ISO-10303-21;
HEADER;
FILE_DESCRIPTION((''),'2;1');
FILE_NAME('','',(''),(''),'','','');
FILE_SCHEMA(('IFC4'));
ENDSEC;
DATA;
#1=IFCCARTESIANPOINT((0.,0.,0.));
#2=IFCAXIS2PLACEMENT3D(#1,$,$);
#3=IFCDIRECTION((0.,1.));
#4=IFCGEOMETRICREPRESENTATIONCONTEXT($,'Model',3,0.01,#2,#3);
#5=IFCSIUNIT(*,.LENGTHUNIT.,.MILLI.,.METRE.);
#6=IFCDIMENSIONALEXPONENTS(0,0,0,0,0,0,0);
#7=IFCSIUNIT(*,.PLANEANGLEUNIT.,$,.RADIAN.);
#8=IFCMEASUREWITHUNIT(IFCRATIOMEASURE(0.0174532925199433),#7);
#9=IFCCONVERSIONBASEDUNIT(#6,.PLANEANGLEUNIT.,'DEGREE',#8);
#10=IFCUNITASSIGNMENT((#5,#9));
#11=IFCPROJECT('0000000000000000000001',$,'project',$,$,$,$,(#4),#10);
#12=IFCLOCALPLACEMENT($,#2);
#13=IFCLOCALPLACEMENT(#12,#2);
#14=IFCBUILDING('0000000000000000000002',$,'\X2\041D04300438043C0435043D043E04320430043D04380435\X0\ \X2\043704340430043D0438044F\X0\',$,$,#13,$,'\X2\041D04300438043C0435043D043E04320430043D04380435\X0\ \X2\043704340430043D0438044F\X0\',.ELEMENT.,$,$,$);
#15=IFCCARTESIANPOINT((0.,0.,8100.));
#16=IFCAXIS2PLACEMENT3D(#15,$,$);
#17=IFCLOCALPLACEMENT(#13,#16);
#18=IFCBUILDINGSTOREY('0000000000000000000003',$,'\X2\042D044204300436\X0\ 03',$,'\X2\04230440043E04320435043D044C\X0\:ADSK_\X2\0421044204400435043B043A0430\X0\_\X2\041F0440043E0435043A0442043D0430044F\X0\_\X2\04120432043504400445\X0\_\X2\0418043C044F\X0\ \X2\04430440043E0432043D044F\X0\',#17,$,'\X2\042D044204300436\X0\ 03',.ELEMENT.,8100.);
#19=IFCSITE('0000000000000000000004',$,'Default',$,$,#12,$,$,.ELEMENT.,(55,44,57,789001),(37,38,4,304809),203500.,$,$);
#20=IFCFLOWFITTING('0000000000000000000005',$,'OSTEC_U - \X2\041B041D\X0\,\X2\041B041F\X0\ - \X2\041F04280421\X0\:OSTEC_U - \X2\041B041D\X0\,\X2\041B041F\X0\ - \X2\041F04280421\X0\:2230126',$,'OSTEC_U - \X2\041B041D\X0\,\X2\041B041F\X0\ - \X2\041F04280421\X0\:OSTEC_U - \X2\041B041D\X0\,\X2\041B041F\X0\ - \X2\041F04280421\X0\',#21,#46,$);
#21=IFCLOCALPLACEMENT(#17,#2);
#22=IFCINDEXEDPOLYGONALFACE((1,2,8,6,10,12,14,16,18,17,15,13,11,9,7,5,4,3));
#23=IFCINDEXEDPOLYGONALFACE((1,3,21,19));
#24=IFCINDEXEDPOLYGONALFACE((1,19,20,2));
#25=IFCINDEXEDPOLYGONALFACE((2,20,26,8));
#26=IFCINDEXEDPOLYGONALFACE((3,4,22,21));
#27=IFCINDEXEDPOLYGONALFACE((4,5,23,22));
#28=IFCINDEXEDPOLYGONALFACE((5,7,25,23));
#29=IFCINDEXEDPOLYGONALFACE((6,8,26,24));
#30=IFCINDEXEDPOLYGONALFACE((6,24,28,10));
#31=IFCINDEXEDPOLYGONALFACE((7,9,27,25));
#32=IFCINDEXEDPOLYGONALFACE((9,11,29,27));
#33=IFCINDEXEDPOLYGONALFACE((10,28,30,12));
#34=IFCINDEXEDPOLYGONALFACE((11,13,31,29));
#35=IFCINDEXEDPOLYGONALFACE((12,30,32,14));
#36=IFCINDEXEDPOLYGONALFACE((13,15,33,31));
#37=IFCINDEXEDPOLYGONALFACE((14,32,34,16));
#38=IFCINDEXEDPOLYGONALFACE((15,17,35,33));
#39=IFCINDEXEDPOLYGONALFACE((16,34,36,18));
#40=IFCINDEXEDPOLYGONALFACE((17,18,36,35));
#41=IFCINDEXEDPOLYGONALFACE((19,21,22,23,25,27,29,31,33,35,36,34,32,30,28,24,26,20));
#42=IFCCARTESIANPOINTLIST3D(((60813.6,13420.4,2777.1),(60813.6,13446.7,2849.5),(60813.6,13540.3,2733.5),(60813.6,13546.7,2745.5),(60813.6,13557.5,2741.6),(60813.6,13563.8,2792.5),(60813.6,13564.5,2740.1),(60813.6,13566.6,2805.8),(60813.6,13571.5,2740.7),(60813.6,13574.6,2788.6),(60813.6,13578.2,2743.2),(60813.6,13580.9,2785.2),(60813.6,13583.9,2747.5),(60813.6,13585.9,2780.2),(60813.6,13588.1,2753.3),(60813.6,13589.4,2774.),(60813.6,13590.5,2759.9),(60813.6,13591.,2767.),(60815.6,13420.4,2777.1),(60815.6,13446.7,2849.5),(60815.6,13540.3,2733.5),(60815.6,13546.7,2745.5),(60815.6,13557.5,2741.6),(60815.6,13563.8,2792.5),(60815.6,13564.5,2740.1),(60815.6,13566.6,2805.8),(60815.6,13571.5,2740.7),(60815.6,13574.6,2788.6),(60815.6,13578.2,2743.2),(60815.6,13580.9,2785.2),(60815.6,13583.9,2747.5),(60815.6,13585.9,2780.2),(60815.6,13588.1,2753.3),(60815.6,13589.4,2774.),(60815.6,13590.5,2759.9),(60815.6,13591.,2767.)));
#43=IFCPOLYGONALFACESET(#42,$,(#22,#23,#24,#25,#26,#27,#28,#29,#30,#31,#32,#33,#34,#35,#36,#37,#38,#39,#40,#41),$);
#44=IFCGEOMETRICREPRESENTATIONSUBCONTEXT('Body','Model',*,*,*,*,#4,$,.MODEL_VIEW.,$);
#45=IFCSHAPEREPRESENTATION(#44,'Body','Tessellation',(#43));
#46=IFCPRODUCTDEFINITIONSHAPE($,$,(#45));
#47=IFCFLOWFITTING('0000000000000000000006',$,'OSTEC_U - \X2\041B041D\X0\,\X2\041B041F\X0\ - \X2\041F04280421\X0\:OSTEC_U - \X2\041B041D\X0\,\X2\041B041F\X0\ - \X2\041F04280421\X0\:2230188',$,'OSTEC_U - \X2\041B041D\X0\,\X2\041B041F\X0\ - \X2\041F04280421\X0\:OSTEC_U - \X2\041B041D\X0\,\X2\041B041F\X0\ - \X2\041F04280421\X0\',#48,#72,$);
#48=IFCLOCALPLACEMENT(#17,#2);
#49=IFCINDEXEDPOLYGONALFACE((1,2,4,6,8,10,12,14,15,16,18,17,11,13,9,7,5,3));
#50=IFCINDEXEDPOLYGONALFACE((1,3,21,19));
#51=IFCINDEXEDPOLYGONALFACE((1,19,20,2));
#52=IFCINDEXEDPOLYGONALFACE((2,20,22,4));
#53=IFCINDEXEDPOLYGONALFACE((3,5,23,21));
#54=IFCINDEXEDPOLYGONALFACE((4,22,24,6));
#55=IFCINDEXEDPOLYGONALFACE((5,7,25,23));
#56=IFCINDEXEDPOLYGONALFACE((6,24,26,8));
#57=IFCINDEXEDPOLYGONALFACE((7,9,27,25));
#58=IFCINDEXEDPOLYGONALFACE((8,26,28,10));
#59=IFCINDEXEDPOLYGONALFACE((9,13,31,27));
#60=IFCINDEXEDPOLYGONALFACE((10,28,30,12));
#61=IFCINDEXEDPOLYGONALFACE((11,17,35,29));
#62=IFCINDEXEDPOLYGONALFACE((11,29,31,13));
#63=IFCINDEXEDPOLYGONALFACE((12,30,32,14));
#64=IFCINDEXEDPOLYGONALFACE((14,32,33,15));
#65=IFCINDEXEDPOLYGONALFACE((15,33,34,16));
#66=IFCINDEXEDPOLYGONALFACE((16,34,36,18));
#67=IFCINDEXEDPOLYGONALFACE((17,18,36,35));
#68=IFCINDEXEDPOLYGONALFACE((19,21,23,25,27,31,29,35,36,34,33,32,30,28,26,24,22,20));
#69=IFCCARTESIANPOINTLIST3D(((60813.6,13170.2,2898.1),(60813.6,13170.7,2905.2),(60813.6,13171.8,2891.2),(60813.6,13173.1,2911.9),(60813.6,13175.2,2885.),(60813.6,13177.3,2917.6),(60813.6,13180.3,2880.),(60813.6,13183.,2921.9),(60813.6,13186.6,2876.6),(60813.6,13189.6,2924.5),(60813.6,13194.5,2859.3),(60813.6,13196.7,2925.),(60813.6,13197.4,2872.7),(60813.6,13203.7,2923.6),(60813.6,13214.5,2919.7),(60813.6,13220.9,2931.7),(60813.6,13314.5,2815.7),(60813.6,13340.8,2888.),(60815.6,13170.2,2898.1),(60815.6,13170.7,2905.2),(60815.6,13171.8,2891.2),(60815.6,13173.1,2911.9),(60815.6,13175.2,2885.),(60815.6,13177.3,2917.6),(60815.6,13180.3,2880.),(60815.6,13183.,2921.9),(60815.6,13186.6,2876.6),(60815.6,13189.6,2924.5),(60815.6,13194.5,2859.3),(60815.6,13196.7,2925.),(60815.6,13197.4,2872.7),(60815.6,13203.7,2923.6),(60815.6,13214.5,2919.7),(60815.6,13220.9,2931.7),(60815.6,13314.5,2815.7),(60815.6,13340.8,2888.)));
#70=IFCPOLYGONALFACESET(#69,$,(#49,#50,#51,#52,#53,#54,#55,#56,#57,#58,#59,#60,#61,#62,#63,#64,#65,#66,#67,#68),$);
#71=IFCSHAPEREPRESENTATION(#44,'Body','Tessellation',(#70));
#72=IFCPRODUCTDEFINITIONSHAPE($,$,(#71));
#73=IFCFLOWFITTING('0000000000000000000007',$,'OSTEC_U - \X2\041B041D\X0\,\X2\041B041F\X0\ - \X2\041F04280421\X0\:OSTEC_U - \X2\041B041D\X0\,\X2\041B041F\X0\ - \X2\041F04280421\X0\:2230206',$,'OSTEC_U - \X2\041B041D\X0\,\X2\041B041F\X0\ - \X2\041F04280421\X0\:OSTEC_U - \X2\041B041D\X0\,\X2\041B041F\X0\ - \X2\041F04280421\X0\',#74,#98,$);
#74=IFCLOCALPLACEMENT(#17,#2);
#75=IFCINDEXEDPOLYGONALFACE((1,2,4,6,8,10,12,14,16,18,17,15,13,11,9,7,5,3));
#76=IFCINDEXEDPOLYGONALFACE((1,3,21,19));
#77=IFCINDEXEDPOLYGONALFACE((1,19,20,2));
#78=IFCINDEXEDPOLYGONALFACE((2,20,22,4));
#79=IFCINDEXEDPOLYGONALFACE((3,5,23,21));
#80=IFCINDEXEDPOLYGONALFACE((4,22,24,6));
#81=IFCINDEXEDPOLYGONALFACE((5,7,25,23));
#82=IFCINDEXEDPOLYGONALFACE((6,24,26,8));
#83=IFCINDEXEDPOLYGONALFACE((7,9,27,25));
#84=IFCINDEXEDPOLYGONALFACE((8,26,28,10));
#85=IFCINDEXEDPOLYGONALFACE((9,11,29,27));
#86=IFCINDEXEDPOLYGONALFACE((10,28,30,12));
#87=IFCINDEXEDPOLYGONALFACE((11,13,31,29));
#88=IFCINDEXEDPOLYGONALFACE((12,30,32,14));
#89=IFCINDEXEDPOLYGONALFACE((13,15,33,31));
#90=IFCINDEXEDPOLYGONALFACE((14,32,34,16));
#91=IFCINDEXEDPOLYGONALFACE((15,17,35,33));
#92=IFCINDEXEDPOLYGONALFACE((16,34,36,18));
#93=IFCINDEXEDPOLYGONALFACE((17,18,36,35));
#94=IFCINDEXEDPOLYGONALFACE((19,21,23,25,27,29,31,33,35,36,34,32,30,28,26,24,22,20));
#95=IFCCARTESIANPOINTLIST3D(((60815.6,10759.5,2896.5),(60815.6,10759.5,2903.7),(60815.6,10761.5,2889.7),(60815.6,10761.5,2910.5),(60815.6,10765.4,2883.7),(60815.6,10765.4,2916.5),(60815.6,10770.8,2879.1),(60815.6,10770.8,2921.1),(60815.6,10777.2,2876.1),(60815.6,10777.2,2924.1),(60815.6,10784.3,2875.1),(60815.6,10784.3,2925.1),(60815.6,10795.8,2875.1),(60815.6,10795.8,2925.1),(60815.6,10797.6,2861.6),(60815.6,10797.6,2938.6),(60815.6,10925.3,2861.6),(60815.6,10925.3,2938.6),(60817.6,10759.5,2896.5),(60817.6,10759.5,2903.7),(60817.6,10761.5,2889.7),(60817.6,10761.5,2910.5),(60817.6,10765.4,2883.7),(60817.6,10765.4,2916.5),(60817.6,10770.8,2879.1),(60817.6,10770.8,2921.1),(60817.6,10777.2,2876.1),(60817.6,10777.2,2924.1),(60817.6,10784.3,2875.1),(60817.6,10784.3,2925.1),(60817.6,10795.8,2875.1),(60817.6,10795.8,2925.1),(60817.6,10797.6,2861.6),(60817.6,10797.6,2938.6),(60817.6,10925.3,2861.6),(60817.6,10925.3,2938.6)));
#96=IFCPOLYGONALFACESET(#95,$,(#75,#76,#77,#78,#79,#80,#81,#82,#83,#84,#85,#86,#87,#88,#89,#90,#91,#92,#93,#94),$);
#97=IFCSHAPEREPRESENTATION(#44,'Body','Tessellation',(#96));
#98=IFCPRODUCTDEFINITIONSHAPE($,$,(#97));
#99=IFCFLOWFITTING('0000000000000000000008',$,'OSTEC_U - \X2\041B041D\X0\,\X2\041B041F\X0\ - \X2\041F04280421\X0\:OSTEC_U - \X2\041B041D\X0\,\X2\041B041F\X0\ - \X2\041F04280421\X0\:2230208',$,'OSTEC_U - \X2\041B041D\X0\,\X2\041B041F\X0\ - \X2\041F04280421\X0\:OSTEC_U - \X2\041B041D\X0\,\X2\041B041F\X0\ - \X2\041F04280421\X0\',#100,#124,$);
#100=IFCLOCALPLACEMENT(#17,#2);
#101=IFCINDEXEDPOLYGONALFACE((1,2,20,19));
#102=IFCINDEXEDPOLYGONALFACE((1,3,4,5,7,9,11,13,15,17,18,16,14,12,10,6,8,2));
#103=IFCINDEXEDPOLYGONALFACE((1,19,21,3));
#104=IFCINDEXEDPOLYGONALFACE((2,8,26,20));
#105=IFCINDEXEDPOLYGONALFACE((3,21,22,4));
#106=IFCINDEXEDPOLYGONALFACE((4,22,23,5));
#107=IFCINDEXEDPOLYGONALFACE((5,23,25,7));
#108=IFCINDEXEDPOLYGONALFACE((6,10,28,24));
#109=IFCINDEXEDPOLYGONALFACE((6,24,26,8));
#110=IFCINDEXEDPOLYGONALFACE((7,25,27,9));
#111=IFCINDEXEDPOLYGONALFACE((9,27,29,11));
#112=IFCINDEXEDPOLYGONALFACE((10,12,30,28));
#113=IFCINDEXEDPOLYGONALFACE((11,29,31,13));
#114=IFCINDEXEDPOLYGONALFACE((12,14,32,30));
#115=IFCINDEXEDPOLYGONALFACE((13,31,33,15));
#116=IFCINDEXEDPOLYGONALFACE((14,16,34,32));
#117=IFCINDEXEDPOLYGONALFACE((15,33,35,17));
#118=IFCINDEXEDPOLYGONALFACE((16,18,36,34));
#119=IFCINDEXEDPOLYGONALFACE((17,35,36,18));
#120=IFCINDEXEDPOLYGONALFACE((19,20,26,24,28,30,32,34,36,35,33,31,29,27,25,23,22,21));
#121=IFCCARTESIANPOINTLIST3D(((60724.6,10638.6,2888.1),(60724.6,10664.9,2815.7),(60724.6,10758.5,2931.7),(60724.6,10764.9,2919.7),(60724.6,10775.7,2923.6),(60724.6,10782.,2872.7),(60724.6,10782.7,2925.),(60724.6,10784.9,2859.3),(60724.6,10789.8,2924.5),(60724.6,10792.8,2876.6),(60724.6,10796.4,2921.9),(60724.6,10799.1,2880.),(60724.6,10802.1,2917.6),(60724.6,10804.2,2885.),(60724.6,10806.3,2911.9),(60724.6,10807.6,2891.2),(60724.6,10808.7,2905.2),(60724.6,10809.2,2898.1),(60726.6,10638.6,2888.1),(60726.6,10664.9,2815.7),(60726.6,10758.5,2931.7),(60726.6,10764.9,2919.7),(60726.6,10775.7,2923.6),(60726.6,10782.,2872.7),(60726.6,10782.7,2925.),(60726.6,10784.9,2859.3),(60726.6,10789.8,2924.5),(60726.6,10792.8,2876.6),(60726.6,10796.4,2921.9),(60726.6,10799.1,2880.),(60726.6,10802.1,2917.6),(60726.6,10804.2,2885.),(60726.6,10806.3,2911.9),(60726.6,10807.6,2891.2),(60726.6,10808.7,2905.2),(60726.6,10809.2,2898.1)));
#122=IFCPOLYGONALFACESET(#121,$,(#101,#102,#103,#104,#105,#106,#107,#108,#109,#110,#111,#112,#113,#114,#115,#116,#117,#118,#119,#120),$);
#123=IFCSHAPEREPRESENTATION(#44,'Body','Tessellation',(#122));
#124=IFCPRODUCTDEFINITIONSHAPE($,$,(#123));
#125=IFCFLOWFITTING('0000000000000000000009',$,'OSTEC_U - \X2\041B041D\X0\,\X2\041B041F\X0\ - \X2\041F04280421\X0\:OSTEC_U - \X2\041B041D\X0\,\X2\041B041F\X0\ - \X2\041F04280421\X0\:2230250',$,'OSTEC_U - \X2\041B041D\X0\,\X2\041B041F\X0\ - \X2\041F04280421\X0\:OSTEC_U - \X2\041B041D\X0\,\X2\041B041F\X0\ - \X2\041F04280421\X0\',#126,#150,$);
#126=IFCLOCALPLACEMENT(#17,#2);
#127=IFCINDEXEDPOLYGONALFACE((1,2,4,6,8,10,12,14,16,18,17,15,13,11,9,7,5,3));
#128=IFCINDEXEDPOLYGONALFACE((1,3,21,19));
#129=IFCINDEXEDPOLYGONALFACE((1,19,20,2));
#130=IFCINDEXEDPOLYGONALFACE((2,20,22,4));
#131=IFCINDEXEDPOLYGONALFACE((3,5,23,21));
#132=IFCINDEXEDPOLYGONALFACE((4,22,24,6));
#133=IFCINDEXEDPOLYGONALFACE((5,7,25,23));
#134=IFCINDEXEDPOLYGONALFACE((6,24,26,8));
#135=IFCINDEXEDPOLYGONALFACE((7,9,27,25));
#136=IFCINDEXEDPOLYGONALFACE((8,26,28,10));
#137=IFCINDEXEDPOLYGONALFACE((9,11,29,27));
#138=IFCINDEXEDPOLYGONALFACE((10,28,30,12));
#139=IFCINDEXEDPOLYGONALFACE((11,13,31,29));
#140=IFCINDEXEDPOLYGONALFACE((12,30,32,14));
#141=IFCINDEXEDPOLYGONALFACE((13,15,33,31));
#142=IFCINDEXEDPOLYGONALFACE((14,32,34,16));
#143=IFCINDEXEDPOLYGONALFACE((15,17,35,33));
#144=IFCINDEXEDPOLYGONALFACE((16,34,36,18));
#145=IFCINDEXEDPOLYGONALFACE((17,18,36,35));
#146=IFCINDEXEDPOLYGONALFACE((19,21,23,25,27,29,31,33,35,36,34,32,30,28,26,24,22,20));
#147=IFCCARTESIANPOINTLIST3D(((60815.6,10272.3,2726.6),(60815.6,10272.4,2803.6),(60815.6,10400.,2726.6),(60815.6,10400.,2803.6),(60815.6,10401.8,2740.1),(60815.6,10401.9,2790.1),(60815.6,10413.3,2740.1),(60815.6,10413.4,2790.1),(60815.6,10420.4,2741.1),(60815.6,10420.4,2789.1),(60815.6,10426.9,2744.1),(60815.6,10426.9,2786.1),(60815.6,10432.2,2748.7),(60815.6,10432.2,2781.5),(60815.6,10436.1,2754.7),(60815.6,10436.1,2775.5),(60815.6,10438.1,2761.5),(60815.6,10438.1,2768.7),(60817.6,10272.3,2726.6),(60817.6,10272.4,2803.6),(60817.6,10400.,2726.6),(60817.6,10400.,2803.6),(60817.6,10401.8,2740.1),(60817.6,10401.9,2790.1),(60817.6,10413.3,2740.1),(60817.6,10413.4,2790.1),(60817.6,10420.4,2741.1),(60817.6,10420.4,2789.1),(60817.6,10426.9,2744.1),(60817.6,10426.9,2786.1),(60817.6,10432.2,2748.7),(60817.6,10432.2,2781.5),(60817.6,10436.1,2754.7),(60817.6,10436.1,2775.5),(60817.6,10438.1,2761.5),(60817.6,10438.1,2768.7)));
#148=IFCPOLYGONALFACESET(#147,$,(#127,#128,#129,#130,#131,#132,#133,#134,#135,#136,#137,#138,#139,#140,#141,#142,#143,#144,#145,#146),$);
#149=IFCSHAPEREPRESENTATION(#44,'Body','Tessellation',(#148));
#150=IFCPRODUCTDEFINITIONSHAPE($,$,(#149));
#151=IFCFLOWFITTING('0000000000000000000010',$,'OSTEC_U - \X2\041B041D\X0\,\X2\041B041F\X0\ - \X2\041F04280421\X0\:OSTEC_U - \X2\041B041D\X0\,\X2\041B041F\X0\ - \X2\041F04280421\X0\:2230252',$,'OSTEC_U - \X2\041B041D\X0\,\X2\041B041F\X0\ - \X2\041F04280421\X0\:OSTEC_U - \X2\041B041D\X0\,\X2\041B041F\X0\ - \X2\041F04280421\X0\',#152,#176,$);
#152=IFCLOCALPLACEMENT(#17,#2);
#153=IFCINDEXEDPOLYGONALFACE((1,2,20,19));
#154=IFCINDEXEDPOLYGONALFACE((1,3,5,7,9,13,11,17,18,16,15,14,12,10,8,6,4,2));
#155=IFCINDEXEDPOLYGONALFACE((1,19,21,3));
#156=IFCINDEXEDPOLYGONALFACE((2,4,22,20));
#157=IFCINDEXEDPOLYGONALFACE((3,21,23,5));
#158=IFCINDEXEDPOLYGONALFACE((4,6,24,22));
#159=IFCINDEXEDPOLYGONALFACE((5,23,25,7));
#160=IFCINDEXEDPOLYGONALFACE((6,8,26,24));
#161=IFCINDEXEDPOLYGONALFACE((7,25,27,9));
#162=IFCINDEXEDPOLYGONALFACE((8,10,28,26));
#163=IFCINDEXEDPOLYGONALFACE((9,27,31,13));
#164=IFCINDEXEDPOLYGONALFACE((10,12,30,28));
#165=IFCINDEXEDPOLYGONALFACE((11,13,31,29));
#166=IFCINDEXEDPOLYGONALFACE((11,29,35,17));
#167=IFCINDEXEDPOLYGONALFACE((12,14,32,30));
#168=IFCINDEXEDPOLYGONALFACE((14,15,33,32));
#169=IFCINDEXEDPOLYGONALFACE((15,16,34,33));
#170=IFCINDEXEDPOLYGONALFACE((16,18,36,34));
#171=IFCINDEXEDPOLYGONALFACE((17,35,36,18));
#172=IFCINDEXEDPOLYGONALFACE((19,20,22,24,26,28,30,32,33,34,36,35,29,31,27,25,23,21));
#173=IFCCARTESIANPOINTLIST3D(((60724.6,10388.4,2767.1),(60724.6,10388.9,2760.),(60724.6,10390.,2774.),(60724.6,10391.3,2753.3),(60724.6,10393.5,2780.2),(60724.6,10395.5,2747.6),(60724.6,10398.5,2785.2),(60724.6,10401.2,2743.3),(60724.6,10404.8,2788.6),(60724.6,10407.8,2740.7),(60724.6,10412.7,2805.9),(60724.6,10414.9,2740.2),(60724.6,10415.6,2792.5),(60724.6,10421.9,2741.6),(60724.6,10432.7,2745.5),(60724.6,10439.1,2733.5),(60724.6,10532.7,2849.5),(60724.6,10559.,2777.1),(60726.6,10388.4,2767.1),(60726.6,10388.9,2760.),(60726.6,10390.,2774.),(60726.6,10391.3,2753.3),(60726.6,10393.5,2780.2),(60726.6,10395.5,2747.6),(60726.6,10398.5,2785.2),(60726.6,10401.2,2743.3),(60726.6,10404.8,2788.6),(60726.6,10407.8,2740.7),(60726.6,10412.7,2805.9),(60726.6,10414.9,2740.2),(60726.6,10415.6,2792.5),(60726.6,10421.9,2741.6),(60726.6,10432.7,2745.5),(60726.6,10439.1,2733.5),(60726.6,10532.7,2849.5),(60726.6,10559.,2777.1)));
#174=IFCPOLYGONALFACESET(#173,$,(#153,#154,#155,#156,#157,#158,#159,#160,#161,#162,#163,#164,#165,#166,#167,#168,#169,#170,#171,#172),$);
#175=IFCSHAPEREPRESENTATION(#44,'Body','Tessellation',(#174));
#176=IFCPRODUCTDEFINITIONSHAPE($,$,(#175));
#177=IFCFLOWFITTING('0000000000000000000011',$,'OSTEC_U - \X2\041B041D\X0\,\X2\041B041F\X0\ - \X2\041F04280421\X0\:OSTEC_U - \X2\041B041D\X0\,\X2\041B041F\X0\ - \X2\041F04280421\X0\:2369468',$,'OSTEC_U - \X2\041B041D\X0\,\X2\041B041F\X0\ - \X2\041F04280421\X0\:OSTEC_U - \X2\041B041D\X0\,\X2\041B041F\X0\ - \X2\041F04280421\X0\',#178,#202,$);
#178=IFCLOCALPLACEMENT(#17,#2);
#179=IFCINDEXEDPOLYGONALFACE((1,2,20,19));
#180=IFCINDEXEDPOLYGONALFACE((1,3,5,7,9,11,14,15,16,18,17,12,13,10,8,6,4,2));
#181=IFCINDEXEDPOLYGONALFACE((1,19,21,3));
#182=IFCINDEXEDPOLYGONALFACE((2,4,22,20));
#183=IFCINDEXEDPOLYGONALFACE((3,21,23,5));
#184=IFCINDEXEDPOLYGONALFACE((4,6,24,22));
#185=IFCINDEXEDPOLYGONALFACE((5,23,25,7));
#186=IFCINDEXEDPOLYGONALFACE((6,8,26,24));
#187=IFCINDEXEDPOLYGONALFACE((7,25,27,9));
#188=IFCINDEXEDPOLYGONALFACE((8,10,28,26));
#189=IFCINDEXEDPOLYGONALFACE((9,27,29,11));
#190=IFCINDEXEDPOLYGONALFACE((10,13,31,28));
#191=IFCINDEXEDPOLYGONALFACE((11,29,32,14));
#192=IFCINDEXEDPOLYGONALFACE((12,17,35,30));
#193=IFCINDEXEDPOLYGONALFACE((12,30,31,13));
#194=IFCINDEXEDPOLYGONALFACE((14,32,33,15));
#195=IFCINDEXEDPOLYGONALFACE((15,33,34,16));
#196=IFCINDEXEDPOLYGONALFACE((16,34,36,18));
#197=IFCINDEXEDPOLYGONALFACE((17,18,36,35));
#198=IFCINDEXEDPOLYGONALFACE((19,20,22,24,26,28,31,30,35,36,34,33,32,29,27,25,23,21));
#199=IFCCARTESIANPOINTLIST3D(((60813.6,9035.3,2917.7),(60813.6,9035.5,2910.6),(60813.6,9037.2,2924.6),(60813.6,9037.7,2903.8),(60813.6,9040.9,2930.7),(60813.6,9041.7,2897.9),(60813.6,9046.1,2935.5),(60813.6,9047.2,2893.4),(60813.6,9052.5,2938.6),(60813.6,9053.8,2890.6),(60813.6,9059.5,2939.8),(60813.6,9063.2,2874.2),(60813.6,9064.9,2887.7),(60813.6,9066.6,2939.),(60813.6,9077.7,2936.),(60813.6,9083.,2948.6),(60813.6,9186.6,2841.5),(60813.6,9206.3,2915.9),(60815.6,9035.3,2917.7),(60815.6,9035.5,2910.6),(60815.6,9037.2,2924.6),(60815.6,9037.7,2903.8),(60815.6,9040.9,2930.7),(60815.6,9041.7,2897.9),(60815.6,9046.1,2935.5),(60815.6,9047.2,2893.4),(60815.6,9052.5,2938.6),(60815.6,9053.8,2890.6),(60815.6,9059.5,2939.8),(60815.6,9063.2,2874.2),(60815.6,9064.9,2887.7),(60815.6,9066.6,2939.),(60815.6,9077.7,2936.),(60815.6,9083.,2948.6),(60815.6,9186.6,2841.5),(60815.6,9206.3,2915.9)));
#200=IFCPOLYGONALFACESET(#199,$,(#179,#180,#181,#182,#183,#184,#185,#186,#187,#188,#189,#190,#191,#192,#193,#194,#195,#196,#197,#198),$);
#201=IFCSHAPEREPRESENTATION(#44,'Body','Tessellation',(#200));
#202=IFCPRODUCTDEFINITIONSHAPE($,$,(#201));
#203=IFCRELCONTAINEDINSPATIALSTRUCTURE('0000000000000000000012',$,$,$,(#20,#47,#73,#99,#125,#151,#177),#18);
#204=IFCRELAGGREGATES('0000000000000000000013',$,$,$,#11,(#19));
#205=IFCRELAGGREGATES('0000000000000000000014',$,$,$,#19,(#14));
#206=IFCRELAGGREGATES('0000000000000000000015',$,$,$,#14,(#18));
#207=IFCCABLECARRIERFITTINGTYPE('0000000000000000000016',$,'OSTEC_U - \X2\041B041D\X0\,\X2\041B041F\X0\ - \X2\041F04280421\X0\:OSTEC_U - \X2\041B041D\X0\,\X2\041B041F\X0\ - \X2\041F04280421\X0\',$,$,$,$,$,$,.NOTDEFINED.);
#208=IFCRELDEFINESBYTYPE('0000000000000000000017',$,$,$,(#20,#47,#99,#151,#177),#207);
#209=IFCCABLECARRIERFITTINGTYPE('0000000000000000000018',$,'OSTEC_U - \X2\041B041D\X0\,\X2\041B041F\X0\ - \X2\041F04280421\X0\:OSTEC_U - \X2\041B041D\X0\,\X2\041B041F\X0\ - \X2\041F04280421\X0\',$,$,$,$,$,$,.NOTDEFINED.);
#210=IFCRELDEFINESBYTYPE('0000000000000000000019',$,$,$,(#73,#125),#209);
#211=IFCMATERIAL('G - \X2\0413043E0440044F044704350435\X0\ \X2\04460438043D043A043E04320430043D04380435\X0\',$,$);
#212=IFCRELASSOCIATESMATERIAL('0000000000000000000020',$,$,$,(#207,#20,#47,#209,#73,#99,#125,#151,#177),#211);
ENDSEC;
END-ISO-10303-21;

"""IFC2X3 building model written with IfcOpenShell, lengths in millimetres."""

from ifc_helpers import new_model, entity, si_unit, converted_unit, direction, frame, frame_2d, origin, place, context, subcontext, project, spatial, polyline, circle_curve, parameter, trimmed, segment, composite_curve, outline, extrude, source, transform, mapped, material, type_object, type_shapes, element, save


model = new_model("IFC2X3")

# Units and contexts
model_context = context("Model", 3, precision=0.01, world=origin(), true_north=direction((0.0, 1.0)))
body_context = subcontext(model_context, "Body", "Model", "MODEL_VIEW")
ifc_project = project(units=[si_unit("LENGTHUNIT", "METRE", prefix="MILLI"), converted_unit("PLANEANGLEUNIT", "DEGREE", entity("IfcRatioMeasure", 0.0174532925199433), si_unit("PLANEANGLEUNIT", "RADIAN"), dimensions=[0, 0, 0, 0, 0, 0, 0])], contexts=[model_context])

# Site, building, storey
site_placement = place(None, origin())
site = spatial("IfcSite", under=ifc_project, at=site_placement, Name="Default", CompositionType="ELEMENT", RefLatitude=(55, 44, 57, 789001), RefLongitude=(37, 38, 4, 304809), RefElevation=203500.0)
building_placement = place(site_placement, origin())
building = spatial("IfcBuilding", under=site, at=building_placement, Name="Наименование здания", LongName="Наименование здания", CompositionType="ELEMENT")
storey_placement = place(building_placement, frame((0.0, 0.0, 8100.0)))
storey = spatial("IfcBuildingStorey", under=building, at=storey_placement, Name="Этаж 03", ObjectType="Уровень:ADSK_Стрелка_Проектная_Вверх_Имя уровня", LongName="Этаж 03", CompositionType="ELEMENT", Elevation=8100.0)

# Flow fittings
ifc_material_1 = material(Name="G - Горячее цинкование")
cable_carrier_fitting_type_1 = type_object("IfcCableCarrierFittingType", Name="OSTEC_U - ЛН,ЛП - ПШС:OSTEC_U - ЛН,ЛП - ПШС", PredefinedType="NOTDEFINED", material=ifc_material_1)
shared_shape_1 = source(origin(), body_context, "Body", "SweptSolid", [
    extrude(outline(composite_curve([segment(trimmed(circle_curve(frame_2d((-41.5, 0.0), x_axis=(1.0, 0.0)), 25.0), [parameter(90.0)], [parameter(270.0)], True, "PARAMETER"), True, "CONTINUOUS"), segment(polyline([(-41.5, -25.0), (-30.0, -25.0)]), True, "CONTINUOUS"), segment(polyline([(-30.0, -25.0), (-28.1, -38.5)]), True, "CONTINUOUS"), segment(polyline([(-28.1, -38.5), (99.5, -38.5)]), True, "CONTINUOUS"), segment(polyline([(99.5, -38.5), (99.5, 38.5)]), True, "CONTINUOUS"), segment(polyline([(99.5, 38.5), (-28.1, 38.5)]), True, "CONTINUOUS"), segment(polyline([(-28.1, 38.5), (-30.0, 25.0)]), True, "CONTINUOUS"), segment(polyline([(-30.0, 25.0), (-41.5, 25.0)]), True, "CONTINUOUS")], self_intersect=False)), frame((41.5, 0.0, 0.0)), (0.0, 0.0, 1.0), 2.0),
])
type_shapes(cable_carrier_fitting_type_1, [shared_shape_1])
for number, where, z_axis, x_axis, name in (
    (1, (60813.6, 13566.0, 2765.1), (1.0, 0.0, 0.0), (0.0, -0.939662, 0.342104), "OSTEC_U - ЛН,ЛП - ПШС:OSTEC_U - ЛН,ЛП - ПШС:2230126"),
    (2, (60813.6, 13195.1, 2900.1), (1.0, 0.0, 0.0), (0.0, 0.939662, -0.342104), "OSTEC_U - ЛН,ЛП - ПШС:OSTEC_U - ЛН,ЛП - ПШС:2230188"),
):
    element("IfcFlowFitting", number, at=place(storey_placement, frame(where, z_axis=z_axis, x_axis=x_axis)), inside=storey, type_object=cable_carrier_fitting_type_1, material=ifc_material_1, Name=name, ObjectType="OSTEC_U - ЛН,ЛП - ПШС:OSTEC_U - ЛН,ЛП - ПШС", context=body_context, shape_type="MappedRepresentation", body=[
        mapped(shared_shape_1, transform((0.0, 0.0, 0.0), scale=1.0)),
    ])
cable_carrier_fitting_type_2 = type_object("IfcCableCarrierFittingType", Name="OSTEC_U - ЛН,ЛП - ПШС:OSTEC_U - ЛН,ЛП - ПШС", PredefinedType="NOTDEFINED", material=ifc_material_1)
type_shapes(cable_carrier_fitting_type_2, [shared_shape_1])
flow_fitting_1_placement = place(storey_placement, frame((60815.6, 10784.3, 2900.1), z_axis=(1.0, 0.0, 0.0), x_axis=(0.0, 1.0, 0.0)))
element("IfcFlowFitting", 3, at=flow_fitting_1_placement, inside=storey, type_object=cable_carrier_fitting_type_2, material=ifc_material_1, Name="OSTEC_U - ЛН,ЛП - ПШС:OSTEC_U - ЛН,ЛП - ПШС:2230206", ObjectType="OSTEC_U - ЛН,ЛП - ПШС:OSTEC_U - ЛН,ЛП - ПШС", context=body_context, shape_type="MappedRepresentation", body=[
    mapped(shared_shape_1, transform((0.0, 0.0, 0.0), scale=1.0)),
])
flow_fitting_2_placement = place(storey_placement, frame((60726.7, 10784.3, 2900.1), z_axis=(-1.0, 0.0, 0.0), x_axis=(0.0, -0.939693, -0.34202)))
element("IfcFlowFitting", 4, at=flow_fitting_2_placement, inside=storey, type_object=cable_carrier_fitting_type_1, material=ifc_material_1, Name="OSTEC_U - ЛН,ЛП - ПШС:OSTEC_U - ЛН,ЛП - ПШС:2230208", ObjectType="OSTEC_U - ЛН,ЛП - ПШС:OSTEC_U - ЛН,ЛП - ПШС", context=body_context, shape_type="MappedRepresentation", body=[
    mapped(shared_shape_1, transform((0.0, 0.0, 0.0), scale=1.0)),
])
flow_fitting_3_placement = place(storey_placement, frame((60815.6, 10413.4, 2765.1), z_axis=(1.0, 0.0, 0.0), x_axis=(0.0, -1.0, 0.000005)))
element("IfcFlowFitting", 5, at=flow_fitting_3_placement, inside=storey, type_object=cable_carrier_fitting_type_2, material=ifc_material_1, Name="OSTEC_U - ЛН,ЛП - ПШС:OSTEC_U - ЛН,ЛП - ПШС:2230250", ObjectType="OSTEC_U - ЛН,ЛП - ПШС:OSTEC_U - ЛН,ЛП - ПШС", context=body_context, shape_type="MappedRepresentation", body=[
    mapped(shared_shape_1, transform((0.0, 0.0, 0.0), scale=1.0)),
])
for number, where, z_axis, x_axis, name in (
    (6, (60726.7, 10413.4, 2765.1), (-1.0, 0.0, 0.0), (0.0, 0.939693, 0.34202), "OSTEC_U - ЛН,ЛП - ПШС:OSTEC_U - ЛН,ЛП - ПШС:2230252"),
    (7, (60813.6, 9060.2, 2914.8), (1.0, 0.0, 0.0), (0.0, 0.966668, -0.256034), "OSTEC_U - ЛН,ЛП - ПШС:OSTEC_U - ЛН,ЛП - ПШС:2369468"),
):
    element("IfcFlowFitting", number, at=place(storey_placement, frame(where, z_axis=z_axis, x_axis=x_axis)), inside=storey, type_object=cable_carrier_fitting_type_1, material=ifc_material_1, Name=name, ObjectType="OSTEC_U - ЛН,ЛП - ПШС:OSTEC_U - ЛН,ЛП - ПШС", context=body_context, shape_type="MappedRepresentation", body=[
        mapped(shared_shape_1, transform((0.0, 0.0, 0.0), scale=1.0)),
    ])

save(model, "model.ifc")
